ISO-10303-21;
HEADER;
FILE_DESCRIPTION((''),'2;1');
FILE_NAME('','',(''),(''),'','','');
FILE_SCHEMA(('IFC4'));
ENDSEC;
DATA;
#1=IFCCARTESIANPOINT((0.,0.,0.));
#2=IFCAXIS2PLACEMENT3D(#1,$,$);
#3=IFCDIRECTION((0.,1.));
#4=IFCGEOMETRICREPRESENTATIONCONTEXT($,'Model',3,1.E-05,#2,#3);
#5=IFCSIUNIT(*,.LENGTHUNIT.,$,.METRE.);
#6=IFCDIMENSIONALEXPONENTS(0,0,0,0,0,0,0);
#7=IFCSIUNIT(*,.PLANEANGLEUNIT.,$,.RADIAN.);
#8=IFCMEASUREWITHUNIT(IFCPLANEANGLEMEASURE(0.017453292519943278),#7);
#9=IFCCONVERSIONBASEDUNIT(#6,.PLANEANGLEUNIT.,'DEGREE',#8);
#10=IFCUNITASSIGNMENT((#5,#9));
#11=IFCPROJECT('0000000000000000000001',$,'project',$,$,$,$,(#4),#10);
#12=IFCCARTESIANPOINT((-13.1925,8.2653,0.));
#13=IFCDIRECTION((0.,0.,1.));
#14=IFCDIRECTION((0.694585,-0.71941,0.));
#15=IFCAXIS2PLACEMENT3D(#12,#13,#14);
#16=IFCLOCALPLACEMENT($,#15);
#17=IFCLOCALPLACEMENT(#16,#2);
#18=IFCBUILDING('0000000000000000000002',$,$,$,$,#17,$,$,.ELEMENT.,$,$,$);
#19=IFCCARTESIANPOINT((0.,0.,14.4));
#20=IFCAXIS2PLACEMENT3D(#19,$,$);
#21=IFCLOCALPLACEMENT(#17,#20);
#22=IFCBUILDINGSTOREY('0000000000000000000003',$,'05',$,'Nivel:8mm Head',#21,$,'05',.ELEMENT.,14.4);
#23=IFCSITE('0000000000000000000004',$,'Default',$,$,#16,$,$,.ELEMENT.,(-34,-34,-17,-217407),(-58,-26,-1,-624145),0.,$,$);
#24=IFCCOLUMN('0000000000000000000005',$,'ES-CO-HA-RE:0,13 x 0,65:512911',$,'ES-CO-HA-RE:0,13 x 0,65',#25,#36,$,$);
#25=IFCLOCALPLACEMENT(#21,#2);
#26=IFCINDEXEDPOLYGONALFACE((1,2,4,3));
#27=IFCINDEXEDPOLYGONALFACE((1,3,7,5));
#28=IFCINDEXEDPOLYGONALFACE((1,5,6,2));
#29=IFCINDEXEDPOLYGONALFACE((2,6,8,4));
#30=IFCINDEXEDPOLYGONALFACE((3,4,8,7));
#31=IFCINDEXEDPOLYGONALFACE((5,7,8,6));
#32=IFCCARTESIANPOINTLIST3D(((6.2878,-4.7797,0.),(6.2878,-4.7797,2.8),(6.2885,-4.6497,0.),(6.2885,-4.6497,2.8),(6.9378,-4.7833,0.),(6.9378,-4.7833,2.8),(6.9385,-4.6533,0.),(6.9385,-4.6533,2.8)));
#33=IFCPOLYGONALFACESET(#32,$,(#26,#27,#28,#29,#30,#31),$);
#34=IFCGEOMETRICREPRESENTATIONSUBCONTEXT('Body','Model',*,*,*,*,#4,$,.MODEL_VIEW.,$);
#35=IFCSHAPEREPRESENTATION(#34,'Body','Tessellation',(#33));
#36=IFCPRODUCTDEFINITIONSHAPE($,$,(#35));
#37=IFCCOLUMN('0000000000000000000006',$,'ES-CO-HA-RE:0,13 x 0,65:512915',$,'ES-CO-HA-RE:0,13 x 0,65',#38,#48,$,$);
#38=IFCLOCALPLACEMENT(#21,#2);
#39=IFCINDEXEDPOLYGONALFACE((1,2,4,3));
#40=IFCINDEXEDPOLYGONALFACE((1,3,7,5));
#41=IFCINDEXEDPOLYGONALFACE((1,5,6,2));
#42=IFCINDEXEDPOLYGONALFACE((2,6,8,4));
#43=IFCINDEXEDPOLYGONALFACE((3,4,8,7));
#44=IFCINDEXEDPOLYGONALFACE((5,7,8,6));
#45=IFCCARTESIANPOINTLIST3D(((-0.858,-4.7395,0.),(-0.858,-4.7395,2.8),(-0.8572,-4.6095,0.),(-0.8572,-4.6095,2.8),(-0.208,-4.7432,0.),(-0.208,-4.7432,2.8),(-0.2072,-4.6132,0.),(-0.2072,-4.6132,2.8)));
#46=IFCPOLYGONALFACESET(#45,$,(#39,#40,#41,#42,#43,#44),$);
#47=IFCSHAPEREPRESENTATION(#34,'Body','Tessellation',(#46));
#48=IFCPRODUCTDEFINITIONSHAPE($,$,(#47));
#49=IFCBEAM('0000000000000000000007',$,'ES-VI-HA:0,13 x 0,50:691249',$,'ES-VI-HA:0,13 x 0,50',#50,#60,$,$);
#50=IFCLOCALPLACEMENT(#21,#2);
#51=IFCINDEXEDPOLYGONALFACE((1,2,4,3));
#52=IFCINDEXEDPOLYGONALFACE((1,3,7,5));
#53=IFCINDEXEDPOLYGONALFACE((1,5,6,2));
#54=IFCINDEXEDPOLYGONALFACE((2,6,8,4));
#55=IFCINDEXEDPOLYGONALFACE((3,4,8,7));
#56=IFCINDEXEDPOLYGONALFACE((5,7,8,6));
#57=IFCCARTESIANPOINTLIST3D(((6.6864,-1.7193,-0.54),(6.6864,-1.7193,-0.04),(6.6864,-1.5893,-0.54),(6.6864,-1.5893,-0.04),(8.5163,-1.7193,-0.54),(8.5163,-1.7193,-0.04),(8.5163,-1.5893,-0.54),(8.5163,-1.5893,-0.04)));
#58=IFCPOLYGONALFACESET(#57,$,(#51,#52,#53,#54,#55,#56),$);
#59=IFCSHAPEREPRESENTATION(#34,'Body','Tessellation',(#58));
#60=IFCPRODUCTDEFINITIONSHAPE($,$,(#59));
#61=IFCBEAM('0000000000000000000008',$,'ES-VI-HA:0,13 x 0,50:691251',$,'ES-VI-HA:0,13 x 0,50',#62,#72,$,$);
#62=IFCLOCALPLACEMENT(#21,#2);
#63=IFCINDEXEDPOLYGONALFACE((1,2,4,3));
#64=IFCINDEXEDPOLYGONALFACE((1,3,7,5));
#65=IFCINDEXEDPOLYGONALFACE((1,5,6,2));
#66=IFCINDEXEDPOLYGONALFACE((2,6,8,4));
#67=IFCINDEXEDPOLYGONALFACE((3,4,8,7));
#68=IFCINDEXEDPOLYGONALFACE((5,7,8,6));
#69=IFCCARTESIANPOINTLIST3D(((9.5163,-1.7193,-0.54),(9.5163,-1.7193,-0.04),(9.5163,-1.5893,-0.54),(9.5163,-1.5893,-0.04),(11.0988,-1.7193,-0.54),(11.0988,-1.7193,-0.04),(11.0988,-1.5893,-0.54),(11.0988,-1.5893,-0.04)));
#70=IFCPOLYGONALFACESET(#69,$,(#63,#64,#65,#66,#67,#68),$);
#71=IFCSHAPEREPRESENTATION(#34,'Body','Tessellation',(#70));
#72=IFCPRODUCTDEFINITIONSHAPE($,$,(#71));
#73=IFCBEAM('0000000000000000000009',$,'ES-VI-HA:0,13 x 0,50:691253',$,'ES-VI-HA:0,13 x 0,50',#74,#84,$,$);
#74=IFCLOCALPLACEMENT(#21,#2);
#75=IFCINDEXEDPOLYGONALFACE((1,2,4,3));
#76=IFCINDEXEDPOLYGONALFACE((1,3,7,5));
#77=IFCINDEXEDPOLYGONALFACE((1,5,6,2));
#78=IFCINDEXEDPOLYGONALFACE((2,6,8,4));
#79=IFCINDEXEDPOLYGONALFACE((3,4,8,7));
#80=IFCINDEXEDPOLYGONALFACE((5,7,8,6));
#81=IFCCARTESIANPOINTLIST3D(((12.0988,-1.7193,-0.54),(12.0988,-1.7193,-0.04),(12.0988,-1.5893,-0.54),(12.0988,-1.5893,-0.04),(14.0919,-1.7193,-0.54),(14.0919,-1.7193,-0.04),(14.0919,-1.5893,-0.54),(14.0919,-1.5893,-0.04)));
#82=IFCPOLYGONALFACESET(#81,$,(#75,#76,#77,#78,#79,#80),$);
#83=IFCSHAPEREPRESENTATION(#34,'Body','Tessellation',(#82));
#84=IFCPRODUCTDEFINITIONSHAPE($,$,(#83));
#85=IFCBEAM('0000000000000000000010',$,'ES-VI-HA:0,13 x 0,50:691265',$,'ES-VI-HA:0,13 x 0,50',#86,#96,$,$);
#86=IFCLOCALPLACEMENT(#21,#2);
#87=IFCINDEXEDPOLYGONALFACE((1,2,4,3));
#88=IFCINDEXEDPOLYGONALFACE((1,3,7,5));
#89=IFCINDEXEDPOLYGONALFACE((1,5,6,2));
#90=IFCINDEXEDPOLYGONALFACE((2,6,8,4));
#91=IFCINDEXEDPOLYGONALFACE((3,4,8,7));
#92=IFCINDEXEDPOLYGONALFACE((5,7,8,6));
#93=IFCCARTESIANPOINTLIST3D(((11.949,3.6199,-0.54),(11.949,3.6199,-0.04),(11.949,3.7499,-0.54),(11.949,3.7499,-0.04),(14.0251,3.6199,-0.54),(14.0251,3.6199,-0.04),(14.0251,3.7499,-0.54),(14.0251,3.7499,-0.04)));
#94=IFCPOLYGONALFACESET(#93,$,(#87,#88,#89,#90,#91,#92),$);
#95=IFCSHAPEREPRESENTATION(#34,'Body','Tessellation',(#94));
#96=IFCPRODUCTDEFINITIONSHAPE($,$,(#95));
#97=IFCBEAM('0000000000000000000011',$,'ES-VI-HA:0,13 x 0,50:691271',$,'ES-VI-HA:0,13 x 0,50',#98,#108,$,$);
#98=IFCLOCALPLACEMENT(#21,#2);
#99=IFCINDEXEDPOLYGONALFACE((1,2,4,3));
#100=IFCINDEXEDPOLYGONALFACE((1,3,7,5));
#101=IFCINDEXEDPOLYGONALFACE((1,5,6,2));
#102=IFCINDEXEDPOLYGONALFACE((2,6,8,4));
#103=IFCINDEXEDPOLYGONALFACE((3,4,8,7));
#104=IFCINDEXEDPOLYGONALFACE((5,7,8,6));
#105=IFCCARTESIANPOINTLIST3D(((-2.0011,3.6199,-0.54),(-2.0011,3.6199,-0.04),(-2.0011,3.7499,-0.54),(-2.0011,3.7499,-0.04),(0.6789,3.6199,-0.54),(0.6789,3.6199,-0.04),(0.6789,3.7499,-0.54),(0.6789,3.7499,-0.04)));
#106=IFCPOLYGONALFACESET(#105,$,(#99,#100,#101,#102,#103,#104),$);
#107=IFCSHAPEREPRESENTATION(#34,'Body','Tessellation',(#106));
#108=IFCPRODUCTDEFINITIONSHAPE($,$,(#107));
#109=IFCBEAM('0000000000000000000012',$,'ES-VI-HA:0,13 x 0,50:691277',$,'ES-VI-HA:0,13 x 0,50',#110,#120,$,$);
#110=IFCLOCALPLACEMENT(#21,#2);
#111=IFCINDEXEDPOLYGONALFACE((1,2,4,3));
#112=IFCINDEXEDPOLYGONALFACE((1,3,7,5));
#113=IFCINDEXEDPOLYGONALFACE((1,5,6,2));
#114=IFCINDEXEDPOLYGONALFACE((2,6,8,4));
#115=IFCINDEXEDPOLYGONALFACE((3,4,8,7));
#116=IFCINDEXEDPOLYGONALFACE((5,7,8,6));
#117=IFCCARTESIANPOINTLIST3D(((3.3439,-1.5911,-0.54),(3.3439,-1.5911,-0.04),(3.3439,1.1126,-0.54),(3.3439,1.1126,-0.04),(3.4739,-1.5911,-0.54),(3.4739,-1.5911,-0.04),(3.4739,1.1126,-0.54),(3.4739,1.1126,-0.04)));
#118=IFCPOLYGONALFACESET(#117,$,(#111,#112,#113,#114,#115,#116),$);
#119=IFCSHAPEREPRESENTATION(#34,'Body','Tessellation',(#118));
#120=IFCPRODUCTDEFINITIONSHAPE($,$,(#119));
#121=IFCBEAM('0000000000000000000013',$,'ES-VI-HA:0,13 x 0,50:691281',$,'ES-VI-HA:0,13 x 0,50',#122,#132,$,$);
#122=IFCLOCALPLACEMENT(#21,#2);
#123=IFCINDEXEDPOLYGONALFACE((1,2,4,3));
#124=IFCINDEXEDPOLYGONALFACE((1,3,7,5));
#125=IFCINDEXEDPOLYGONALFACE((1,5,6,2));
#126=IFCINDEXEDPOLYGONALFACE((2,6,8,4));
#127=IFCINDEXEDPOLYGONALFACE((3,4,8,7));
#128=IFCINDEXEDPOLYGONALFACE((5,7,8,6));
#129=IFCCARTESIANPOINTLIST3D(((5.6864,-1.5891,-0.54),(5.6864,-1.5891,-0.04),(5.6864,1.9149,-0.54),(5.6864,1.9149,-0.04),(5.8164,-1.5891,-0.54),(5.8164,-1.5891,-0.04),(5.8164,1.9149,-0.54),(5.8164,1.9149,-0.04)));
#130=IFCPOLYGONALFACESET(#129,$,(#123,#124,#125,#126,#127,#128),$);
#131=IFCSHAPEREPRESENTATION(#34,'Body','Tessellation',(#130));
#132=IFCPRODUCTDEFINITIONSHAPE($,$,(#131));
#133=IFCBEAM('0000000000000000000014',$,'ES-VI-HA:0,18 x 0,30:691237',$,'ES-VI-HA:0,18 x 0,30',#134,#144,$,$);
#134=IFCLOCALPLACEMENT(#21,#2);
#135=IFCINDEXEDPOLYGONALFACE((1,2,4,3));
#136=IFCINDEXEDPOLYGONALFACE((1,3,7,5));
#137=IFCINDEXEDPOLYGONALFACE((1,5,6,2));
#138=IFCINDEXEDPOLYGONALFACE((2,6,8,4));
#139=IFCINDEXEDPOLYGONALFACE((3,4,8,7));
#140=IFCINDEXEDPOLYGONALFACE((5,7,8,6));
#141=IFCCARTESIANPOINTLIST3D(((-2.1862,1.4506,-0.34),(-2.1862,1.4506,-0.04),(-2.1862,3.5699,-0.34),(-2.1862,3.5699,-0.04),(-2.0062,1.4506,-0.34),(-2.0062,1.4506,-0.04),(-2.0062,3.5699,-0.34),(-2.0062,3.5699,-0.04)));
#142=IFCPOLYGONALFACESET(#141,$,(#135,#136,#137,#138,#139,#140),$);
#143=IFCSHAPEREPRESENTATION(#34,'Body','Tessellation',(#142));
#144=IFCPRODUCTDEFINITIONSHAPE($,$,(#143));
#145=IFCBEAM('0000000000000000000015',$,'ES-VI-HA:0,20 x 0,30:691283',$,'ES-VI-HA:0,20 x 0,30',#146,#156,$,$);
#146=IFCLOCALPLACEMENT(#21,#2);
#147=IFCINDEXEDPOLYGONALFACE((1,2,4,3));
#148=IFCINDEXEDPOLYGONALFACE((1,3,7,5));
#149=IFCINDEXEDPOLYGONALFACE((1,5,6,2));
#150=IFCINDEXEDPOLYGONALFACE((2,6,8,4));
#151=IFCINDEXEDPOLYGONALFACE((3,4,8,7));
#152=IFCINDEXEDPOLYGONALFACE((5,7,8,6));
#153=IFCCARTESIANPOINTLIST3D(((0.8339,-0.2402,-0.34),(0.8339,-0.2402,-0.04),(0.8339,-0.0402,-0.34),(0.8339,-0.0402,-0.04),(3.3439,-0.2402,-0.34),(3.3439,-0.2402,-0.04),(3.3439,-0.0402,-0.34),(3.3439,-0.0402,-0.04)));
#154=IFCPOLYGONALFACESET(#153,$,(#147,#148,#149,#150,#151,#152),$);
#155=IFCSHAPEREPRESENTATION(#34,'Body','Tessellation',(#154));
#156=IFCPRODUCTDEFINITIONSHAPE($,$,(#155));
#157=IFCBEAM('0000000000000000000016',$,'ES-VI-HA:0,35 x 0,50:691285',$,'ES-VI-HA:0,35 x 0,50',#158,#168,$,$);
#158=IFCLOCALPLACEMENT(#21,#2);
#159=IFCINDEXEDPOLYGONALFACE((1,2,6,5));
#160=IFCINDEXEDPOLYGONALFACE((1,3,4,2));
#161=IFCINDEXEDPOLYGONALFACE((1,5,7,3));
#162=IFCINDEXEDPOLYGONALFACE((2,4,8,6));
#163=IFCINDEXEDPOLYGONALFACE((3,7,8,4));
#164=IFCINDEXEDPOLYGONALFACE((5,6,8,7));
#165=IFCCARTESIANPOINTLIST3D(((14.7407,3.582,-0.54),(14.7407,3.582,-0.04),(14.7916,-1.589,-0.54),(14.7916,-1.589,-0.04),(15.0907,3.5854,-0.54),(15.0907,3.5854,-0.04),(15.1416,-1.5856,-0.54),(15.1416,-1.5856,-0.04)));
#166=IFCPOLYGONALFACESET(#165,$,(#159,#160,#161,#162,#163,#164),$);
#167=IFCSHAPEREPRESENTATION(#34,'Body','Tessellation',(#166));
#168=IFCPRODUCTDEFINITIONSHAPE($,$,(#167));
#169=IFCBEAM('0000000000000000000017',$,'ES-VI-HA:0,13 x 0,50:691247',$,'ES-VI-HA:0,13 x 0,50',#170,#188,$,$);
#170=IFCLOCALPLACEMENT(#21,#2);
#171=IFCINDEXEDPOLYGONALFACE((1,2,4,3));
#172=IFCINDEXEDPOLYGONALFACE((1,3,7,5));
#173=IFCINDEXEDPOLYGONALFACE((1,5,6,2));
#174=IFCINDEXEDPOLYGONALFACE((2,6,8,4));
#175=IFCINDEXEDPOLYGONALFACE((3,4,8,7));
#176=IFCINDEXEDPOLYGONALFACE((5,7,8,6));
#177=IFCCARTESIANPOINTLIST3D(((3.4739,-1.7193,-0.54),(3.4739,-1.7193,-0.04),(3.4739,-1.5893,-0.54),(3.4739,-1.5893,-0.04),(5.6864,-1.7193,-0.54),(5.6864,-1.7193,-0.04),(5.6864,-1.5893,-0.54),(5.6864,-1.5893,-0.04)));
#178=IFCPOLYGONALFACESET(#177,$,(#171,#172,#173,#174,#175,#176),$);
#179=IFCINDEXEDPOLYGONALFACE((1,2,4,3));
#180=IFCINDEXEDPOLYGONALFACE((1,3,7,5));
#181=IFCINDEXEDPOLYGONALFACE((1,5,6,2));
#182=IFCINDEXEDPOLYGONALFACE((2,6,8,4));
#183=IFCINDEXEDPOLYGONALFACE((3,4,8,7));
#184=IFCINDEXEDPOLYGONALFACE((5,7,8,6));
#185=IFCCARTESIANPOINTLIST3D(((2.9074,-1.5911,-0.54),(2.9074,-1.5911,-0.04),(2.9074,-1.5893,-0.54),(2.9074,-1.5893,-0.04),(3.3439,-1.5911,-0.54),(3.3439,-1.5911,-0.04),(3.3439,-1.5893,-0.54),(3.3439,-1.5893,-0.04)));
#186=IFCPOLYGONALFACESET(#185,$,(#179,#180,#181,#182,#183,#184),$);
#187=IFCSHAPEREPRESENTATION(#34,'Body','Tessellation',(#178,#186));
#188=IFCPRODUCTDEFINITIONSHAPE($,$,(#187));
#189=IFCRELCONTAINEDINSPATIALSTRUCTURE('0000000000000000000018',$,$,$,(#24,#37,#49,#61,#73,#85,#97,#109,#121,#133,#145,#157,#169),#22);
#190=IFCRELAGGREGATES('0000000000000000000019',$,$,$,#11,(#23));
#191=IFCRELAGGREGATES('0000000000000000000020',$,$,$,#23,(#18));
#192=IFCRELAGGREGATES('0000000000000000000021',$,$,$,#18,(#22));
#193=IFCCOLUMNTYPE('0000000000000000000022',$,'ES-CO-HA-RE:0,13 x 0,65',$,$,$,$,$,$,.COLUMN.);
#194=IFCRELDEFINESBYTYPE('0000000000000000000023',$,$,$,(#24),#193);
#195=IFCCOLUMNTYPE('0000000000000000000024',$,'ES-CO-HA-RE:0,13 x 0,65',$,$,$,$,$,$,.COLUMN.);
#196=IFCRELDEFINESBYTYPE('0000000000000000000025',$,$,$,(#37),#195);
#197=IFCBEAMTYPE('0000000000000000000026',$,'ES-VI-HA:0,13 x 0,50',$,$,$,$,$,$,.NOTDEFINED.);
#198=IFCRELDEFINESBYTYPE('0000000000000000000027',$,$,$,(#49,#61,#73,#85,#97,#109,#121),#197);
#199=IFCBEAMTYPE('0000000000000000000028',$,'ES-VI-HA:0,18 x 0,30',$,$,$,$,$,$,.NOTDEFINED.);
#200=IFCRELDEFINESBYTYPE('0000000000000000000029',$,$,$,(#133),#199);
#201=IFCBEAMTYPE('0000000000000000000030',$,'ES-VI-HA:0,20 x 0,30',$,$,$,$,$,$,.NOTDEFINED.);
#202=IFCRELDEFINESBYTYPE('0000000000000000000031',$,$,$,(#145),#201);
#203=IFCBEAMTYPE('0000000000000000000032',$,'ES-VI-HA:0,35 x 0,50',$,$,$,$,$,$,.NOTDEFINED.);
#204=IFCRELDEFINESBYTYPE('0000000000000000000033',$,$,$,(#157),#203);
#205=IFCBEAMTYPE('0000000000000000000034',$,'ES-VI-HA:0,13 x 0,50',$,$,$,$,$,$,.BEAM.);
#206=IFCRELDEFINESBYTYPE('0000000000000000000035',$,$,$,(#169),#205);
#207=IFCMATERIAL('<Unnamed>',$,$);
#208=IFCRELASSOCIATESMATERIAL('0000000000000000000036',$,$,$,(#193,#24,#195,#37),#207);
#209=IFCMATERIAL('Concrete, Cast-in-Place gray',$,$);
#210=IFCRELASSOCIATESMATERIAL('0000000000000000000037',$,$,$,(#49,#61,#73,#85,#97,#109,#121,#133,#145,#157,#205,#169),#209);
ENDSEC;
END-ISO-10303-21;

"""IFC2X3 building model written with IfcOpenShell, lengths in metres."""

from ifc_helpers import new_model, entity, si_unit, converted_unit, direction, frame, frame_2d, origin, place, context, subcontext, project, spatial, rectangle, extrude, source, transform, mapped, material, type_object, type_shapes, element, save


model = new_model("IFC2X3")

# Units and contexts
model_context = context("Model", 3, precision=1e-05, world=origin(), true_north=direction((0.0, 1.0)))
body_context = subcontext(model_context, "Body", "Model", "MODEL_VIEW")
ifc_project = project(units=[si_unit("LENGTHUNIT", "METRE"), converted_unit("PLANEANGLEUNIT", "DEGREE", entity("IfcPlaneAngleMeasure", 0.017453292519943278), si_unit("PLANEANGLEUNIT", "RADIAN"), dimensions=[0, 0, 0, 0, 0, 0, 0])], contexts=[model_context])

# Site, building, storey
site_placement = place(None, frame((-13.1925, 8.2653, 0.0), z_axis=(0.0, 0.0, 1.0), x_axis=(0.694585, -0.71941, 0.0)))
site = spatial("IfcSite", under=ifc_project, at=site_placement, Name="Default", CompositionType="ELEMENT", RefLatitude=(-34, -34, -17, -217407), RefLongitude=(-58, -26, -1, -624145), RefElevation=0.0)
building_placement = place(site_placement, origin())
building = spatial("IfcBuilding", under=site, at=building_placement, CompositionType="ELEMENT")
storey_placement = place(building_placement, frame((0.0, 0.0, 14.4)))
storey = spatial("IfcBuildingStorey", under=building, at=storey_placement, Name="05", ObjectType="Nivel:8mm Head", LongName="05", CompositionType="ELEMENT", Elevation=14.4)

# Columns
ifc_material_1 = material(Name="<Unnamed>")
column_type_1 = type_object("IfcColumnType", Name="ES-CO-HA-RE:0,13 x 0,65", PredefinedType="COLUMN", material=ifc_material_1)
shared_shape_1 = source(origin(), body_context, "Body", "SweptSolid", [
    extrude(rectangle(XDim=0.65, YDim=0.13, at=frame_2d((0.0, 0.0), x_axis=(1.0, 0.0))), frame((6.6131, -4.7165, 14.4), z_axis=(0.0, 0.0, 1.0), x_axis=(-0.999984, 0.005619, 0.0)), (0.0, 0.0, 1.0), 2.8),
])
type_shapes(column_type_1, [shared_shape_1])
column_1_placement = place(storey_placement, frame((0.0, 0.0, -14.4)))
element("IfcColumn", 1, at=column_1_placement, inside=storey, type_object=column_type_1, material=ifc_material_1, Name="ES-CO-HA-RE:0,13 x 0,65:512911", ObjectType="ES-CO-HA-RE:0,13 x 0,65", context=body_context, shape_type="MappedRepresentation", body=[
    mapped(shared_shape_1, transform((0.0, 0.0, 0.0), scale=1.0)),
])
column_type_2 = type_object("IfcColumnType", Name="ES-CO-HA-RE:0,13 x 0,65", PredefinedType="COLUMN", material=ifc_material_1)
shared_shape_2 = source(origin(), body_context, "Body", "SweptSolid", [
    extrude(rectangle(XDim=0.65, YDim=0.13, at=frame_2d((0.0, 0.0), x_axis=(1.0, 0.0))), frame((-0.5326, -4.6764, 14.4), z_axis=(0.0, 0.0, 1.0), x_axis=(-0.999984, 0.005619, 0.0)), (0.0, 0.0, 1.0), 2.8),
])
type_shapes(column_type_2, [shared_shape_2])
column_2_placement = place(storey_placement, frame((0.0, 0.0, -14.4)))
element("IfcColumn", 2, at=column_2_placement, inside=storey, type_object=column_type_2, material=ifc_material_1, Name="ES-CO-HA-RE:0,13 x 0,65:512915", ObjectType="ES-CO-HA-RE:0,13 x 0,65", context=body_context, shape_type="MappedRepresentation", body=[
    mapped(shared_shape_2, transform((0.0, 0.0, 0.0), scale=1.0)),
])

# Beams
ifc_material_2 = material(Name="Concrete, Cast-in-Place gray")
beam_type_1 = type_object("IfcBeamType", Name="ES-VI-HA:0,13 x 0,50", PredefinedType="NOTDEFINED")
beam_1_placement = place(storey_placement, frame((5.7373, -1.6543, -0.04)))
element("IfcBeam", 3, at=beam_1_placement, inside=storey, type_object=beam_type_1, material=ifc_material_2, Name="ES-VI-HA:0,13 x 0,50:691249", ObjectType="ES-VI-HA:0,13 x 0,50", context=body_context, shape_type="SweptSolid", body=[
    extrude(rectangle(XDim=0.5, YDim=0.13, at=frame_2d((0.0, 0.0), x_axis=(1.0, 0.0))), frame((0.9491, 0.0, -0.25), z_axis=(1.0, 0.0, 0.0), x_axis=(0.0, 0.0, -1.0)), (0.0, 0.0, 1.0), 1.8299),
])
beam_2_placement = place(storey_placement, frame((8.3198, -1.6543, -0.04)))
element("IfcBeam", 4, at=beam_2_placement, inside=storey, type_object=beam_type_1, material=ifc_material_2, Name="ES-VI-HA:0,13 x 0,50:691251", ObjectType="ES-VI-HA:0,13 x 0,50", context=body_context, shape_type="SweptSolid", body=[
    extrude(rectangle(XDim=0.5, YDim=0.13, at=frame_2d((0.0, 0.0), x_axis=(1.0, 0.0))), frame((1.1965, 0.0, -0.25), z_axis=(1.0, 0.0, 0.0), x_axis=(0.0, 0.0, -1.0)), (0.0, 0.0, 1.0), 1.5825),
])
beam_3_placement = place(storey_placement, frame((11.3129, -1.6543, -0.04)))
element("IfcBeam", 5, at=beam_3_placement, inside=storey, type_object=beam_type_1, material=ifc_material_2, Name="ES-VI-HA:0,13 x 0,50:691253", ObjectType="ES-VI-HA:0,13 x 0,50", context=body_context, shape_type="SweptSolid", body=[
    extrude(rectangle(XDim=0.5, YDim=0.13, at=frame_2d((0.0, 0.0), x_axis=(1.0, 0.0))), frame((0.7858, 0.0, -0.25), z_axis=(1.0, 0.0, 0.0), x_axis=(0.0, 0.0, -1.0)), (0.0, 0.0, 1.0), 1.9932),
])
beam_4_placement = place(storey_placement, frame((11.624, 3.6849, -0.04)))
element("IfcBeam", 6, at=beam_4_placement, inside=storey, type_object=beam_type_1, material=ifc_material_2, Name="ES-VI-HA:0,13 x 0,50:691265", ObjectType="ES-VI-HA:0,13 x 0,50", context=body_context, shape_type="SweptSolid", body=[
    extrude(rectangle(XDim=0.5, YDim=0.13, at=frame_2d((0.0, 0.0), x_axis=(1.0, 0.0))), frame((0.325, 0.0, -0.25), z_axis=(1.0, 0.0, 0.0), x_axis=(0.0, 0.0, -1.0)), (0.0, 0.0, 1.0), 2.0761),
])
beam_5_placement = place(storey_placement, frame((-2.0011, 3.6849, -0.04)))
element("IfcBeam", 7, at=beam_5_placement, inside=storey, type_object=beam_type_1, material=ifc_material_2, Name="ES-VI-HA:0,13 x 0,50:691271", ObjectType="ES-VI-HA:0,13 x 0,50", context=body_context, shape_type="SweptSolid", body=[
    extrude(rectangle(XDim=0.5, YDim=0.13, at=frame_2d((0.0, 0.0), x_axis=(1.0, 0.0))), frame((0.0, 0.0, -0.25), z_axis=(1.0, 0.0, 0.0), x_axis=(0.0, 0.0, -1.0)), (0.0, 0.0, 1.0), 2.68),
])
beam_6_placement = place(storey_placement, frame((3.4089, -1.5916, -0.04), z_axis=(0.0, 0.0, 1.0), x_axis=(0.0, 1.0, 0.0)))
element("IfcBeam", 8, at=beam_6_placement, inside=storey, type_object=beam_type_1, material=ifc_material_2, Name="ES-VI-HA:0,13 x 0,50:691277", ObjectType="ES-VI-HA:0,13 x 0,50", context=body_context, shape_type="SweptSolid", body=[
    extrude(rectangle(XDim=0.5, YDim=0.13, at=frame_2d((0.0, 0.0), x_axis=(1.0, 0.0))), frame((0.0005, 0.0, -0.25), z_axis=(1.0, 0.0, 0.0), x_axis=(0.0, 0.0, -1.0)), (0.0, 0.0, 1.0), 2.7037),
])
beam_7_placement = place(storey_placement, frame((5.7514, -1.5891, -0.04), z_axis=(0.0, 0.0, 1.0), x_axis=(0.0, 1.0, 0.0)))
element("IfcBeam", 9, at=beam_7_placement, inside=storey, type_object=beam_type_1, material=ifc_material_2, Name="ES-VI-HA:0,13 x 0,50:691281", ObjectType="ES-VI-HA:0,13 x 0,50", context=body_context, shape_type="SweptSolid", body=[
    extrude(rectangle(XDim=0.5, YDim=0.13, at=frame_2d((0.0, 0.0), x_axis=(1.0, 0.0))), frame((0.0, 0.0, -0.25), z_axis=(1.0, 0.0, 0.0), x_axis=(0.0, 0.0, -1.0)), (0.0, 0.0, 1.0), 3.5039),
])
beam_type_2 = type_object("IfcBeamType", Name="ES-VI-HA:0,18 x 0,30", PredefinedType="NOTDEFINED")
beam_8_placement = place(storey_placement, frame((-2.0962, 3.5699, -0.04), z_axis=(0.0, 0.0, 1.0), x_axis=(0.0, -1.0, 0.0)))
element("IfcBeam", 10, at=beam_8_placement, inside=storey, type_object=beam_type_2, material=ifc_material_2, Name="ES-VI-HA:0,18 x 0,30:691237", ObjectType="ES-VI-HA:0,18 x 0,30", context=body_context, shape_type="SweptSolid", body=[
    extrude(rectangle(XDim=0.3, YDim=0.18, at=frame_2d((0.0, 0.0), x_axis=(1.0, 0.0))), frame((0.0, 0.0, -0.15), z_axis=(1.0, 0.0, 0.0), x_axis=(0.0, 0.0, -1.0)), (0.0, 0.0, 1.0), 2.1193),
])
beam_type_3 = type_object("IfcBeamType", Name="ES-VI-HA:0,20 x 0,30", PredefinedType="NOTDEFINED")
beam_9_placement = place(storey_placement, frame((0.7589, -0.1402, -0.04)))
element("IfcBeam", 11, at=beam_9_placement, inside=storey, type_object=beam_type_3, material=ifc_material_2, Name="ES-VI-HA:0,20 x 0,30:691283", ObjectType="ES-VI-HA:0,20 x 0,30", context=body_context, shape_type="SweptSolid", body=[
    extrude(rectangle(XDim=0.3, YDim=0.2, at=frame_2d((0.0, 0.0), x_axis=(1.0, 0.0))), frame((0.075, 0.0, -0.15), z_axis=(1.0, 0.0, 0.0), x_axis=(0.0, 0.0, -1.0)), (0.0, 0.0, 1.0), 2.51),
])
beam_type_4 = type_object("IfcBeamType", Name="ES-VI-HA:0,35 x 0,50", PredefinedType="NOTDEFINED")
beam_10_placement = place(storey_placement, frame((14.9158, 3.5724, -0.04), z_axis=(0.0, 0.0, 1.0), x_axis=(0.009844, -0.999952, 0.0)))
element("IfcBeam", 12, at=beam_10_placement, inside=storey, type_object=beam_type_4, material=ifc_material_2, Name="ES-VI-HA:0,35 x 0,50:691285", ObjectType="ES-VI-HA:0,35 x 0,50", context=body_context, shape_type="SweptSolid", body=[
    extrude(rectangle(XDim=0.5, YDim=0.35, at=frame_2d((0.0, 0.0), x_axis=(1.0, 0.0))), frame((-0.0113, 0.0, -0.25), z_axis=(1.0, 0.0, 0.0), x_axis=(0.0, 0.0, -1.0)), (0.0, 0.0, 1.0), 5.1713),
])
beam_type_5 = type_object("IfcBeamType", Name="ES-VI-HA:0,13 x 0,50", PredefinedType="BEAM", material=ifc_material_2)
shared_shape_3 = source(origin(), body_context, "Body", "SweptSolid", [
    extrude(rectangle(XDim=0.5, YDim=0.13, at=frame_2d((0.0, 0.0), x_axis=(1.0, 0.0))), frame((3.4739, -1.6543, 14.11), z_axis=(1.0, 0.0, 0.0), x_axis=(0.0, 0.0, -1.0)), (0.0, 0.0, 1.0), 2.2125),
    extrude(rectangle(XDim=0.5, YDim=0.0018, at=frame_2d((0.0, 0.0), x_axis=(1.0, 0.0))), frame((2.9074, -1.5902, 14.11), z_axis=(1.0, 0.0, 0.0), x_axis=(0.0, 0.0, -1.0)), (0.0, 0.0, 1.0), 0.4365),
])
type_shapes(beam_type_5, [shared_shape_3])
beam_11_placement = place(storey_placement, frame((0.0, 0.0, -14.4)))
element("IfcBeam", 13, at=beam_11_placement, inside=storey, type_object=beam_type_5, material=ifc_material_2, Name="ES-VI-HA:0,13 x 0,50:691247", ObjectType="ES-VI-HA:0,13 x 0,50", context=body_context, shape_type="MappedRepresentation", body=[
    mapped(shared_shape_3, transform((0.0, 0.0, 0.0), scale=1.0)),
])

save(model, "model.ifc")
